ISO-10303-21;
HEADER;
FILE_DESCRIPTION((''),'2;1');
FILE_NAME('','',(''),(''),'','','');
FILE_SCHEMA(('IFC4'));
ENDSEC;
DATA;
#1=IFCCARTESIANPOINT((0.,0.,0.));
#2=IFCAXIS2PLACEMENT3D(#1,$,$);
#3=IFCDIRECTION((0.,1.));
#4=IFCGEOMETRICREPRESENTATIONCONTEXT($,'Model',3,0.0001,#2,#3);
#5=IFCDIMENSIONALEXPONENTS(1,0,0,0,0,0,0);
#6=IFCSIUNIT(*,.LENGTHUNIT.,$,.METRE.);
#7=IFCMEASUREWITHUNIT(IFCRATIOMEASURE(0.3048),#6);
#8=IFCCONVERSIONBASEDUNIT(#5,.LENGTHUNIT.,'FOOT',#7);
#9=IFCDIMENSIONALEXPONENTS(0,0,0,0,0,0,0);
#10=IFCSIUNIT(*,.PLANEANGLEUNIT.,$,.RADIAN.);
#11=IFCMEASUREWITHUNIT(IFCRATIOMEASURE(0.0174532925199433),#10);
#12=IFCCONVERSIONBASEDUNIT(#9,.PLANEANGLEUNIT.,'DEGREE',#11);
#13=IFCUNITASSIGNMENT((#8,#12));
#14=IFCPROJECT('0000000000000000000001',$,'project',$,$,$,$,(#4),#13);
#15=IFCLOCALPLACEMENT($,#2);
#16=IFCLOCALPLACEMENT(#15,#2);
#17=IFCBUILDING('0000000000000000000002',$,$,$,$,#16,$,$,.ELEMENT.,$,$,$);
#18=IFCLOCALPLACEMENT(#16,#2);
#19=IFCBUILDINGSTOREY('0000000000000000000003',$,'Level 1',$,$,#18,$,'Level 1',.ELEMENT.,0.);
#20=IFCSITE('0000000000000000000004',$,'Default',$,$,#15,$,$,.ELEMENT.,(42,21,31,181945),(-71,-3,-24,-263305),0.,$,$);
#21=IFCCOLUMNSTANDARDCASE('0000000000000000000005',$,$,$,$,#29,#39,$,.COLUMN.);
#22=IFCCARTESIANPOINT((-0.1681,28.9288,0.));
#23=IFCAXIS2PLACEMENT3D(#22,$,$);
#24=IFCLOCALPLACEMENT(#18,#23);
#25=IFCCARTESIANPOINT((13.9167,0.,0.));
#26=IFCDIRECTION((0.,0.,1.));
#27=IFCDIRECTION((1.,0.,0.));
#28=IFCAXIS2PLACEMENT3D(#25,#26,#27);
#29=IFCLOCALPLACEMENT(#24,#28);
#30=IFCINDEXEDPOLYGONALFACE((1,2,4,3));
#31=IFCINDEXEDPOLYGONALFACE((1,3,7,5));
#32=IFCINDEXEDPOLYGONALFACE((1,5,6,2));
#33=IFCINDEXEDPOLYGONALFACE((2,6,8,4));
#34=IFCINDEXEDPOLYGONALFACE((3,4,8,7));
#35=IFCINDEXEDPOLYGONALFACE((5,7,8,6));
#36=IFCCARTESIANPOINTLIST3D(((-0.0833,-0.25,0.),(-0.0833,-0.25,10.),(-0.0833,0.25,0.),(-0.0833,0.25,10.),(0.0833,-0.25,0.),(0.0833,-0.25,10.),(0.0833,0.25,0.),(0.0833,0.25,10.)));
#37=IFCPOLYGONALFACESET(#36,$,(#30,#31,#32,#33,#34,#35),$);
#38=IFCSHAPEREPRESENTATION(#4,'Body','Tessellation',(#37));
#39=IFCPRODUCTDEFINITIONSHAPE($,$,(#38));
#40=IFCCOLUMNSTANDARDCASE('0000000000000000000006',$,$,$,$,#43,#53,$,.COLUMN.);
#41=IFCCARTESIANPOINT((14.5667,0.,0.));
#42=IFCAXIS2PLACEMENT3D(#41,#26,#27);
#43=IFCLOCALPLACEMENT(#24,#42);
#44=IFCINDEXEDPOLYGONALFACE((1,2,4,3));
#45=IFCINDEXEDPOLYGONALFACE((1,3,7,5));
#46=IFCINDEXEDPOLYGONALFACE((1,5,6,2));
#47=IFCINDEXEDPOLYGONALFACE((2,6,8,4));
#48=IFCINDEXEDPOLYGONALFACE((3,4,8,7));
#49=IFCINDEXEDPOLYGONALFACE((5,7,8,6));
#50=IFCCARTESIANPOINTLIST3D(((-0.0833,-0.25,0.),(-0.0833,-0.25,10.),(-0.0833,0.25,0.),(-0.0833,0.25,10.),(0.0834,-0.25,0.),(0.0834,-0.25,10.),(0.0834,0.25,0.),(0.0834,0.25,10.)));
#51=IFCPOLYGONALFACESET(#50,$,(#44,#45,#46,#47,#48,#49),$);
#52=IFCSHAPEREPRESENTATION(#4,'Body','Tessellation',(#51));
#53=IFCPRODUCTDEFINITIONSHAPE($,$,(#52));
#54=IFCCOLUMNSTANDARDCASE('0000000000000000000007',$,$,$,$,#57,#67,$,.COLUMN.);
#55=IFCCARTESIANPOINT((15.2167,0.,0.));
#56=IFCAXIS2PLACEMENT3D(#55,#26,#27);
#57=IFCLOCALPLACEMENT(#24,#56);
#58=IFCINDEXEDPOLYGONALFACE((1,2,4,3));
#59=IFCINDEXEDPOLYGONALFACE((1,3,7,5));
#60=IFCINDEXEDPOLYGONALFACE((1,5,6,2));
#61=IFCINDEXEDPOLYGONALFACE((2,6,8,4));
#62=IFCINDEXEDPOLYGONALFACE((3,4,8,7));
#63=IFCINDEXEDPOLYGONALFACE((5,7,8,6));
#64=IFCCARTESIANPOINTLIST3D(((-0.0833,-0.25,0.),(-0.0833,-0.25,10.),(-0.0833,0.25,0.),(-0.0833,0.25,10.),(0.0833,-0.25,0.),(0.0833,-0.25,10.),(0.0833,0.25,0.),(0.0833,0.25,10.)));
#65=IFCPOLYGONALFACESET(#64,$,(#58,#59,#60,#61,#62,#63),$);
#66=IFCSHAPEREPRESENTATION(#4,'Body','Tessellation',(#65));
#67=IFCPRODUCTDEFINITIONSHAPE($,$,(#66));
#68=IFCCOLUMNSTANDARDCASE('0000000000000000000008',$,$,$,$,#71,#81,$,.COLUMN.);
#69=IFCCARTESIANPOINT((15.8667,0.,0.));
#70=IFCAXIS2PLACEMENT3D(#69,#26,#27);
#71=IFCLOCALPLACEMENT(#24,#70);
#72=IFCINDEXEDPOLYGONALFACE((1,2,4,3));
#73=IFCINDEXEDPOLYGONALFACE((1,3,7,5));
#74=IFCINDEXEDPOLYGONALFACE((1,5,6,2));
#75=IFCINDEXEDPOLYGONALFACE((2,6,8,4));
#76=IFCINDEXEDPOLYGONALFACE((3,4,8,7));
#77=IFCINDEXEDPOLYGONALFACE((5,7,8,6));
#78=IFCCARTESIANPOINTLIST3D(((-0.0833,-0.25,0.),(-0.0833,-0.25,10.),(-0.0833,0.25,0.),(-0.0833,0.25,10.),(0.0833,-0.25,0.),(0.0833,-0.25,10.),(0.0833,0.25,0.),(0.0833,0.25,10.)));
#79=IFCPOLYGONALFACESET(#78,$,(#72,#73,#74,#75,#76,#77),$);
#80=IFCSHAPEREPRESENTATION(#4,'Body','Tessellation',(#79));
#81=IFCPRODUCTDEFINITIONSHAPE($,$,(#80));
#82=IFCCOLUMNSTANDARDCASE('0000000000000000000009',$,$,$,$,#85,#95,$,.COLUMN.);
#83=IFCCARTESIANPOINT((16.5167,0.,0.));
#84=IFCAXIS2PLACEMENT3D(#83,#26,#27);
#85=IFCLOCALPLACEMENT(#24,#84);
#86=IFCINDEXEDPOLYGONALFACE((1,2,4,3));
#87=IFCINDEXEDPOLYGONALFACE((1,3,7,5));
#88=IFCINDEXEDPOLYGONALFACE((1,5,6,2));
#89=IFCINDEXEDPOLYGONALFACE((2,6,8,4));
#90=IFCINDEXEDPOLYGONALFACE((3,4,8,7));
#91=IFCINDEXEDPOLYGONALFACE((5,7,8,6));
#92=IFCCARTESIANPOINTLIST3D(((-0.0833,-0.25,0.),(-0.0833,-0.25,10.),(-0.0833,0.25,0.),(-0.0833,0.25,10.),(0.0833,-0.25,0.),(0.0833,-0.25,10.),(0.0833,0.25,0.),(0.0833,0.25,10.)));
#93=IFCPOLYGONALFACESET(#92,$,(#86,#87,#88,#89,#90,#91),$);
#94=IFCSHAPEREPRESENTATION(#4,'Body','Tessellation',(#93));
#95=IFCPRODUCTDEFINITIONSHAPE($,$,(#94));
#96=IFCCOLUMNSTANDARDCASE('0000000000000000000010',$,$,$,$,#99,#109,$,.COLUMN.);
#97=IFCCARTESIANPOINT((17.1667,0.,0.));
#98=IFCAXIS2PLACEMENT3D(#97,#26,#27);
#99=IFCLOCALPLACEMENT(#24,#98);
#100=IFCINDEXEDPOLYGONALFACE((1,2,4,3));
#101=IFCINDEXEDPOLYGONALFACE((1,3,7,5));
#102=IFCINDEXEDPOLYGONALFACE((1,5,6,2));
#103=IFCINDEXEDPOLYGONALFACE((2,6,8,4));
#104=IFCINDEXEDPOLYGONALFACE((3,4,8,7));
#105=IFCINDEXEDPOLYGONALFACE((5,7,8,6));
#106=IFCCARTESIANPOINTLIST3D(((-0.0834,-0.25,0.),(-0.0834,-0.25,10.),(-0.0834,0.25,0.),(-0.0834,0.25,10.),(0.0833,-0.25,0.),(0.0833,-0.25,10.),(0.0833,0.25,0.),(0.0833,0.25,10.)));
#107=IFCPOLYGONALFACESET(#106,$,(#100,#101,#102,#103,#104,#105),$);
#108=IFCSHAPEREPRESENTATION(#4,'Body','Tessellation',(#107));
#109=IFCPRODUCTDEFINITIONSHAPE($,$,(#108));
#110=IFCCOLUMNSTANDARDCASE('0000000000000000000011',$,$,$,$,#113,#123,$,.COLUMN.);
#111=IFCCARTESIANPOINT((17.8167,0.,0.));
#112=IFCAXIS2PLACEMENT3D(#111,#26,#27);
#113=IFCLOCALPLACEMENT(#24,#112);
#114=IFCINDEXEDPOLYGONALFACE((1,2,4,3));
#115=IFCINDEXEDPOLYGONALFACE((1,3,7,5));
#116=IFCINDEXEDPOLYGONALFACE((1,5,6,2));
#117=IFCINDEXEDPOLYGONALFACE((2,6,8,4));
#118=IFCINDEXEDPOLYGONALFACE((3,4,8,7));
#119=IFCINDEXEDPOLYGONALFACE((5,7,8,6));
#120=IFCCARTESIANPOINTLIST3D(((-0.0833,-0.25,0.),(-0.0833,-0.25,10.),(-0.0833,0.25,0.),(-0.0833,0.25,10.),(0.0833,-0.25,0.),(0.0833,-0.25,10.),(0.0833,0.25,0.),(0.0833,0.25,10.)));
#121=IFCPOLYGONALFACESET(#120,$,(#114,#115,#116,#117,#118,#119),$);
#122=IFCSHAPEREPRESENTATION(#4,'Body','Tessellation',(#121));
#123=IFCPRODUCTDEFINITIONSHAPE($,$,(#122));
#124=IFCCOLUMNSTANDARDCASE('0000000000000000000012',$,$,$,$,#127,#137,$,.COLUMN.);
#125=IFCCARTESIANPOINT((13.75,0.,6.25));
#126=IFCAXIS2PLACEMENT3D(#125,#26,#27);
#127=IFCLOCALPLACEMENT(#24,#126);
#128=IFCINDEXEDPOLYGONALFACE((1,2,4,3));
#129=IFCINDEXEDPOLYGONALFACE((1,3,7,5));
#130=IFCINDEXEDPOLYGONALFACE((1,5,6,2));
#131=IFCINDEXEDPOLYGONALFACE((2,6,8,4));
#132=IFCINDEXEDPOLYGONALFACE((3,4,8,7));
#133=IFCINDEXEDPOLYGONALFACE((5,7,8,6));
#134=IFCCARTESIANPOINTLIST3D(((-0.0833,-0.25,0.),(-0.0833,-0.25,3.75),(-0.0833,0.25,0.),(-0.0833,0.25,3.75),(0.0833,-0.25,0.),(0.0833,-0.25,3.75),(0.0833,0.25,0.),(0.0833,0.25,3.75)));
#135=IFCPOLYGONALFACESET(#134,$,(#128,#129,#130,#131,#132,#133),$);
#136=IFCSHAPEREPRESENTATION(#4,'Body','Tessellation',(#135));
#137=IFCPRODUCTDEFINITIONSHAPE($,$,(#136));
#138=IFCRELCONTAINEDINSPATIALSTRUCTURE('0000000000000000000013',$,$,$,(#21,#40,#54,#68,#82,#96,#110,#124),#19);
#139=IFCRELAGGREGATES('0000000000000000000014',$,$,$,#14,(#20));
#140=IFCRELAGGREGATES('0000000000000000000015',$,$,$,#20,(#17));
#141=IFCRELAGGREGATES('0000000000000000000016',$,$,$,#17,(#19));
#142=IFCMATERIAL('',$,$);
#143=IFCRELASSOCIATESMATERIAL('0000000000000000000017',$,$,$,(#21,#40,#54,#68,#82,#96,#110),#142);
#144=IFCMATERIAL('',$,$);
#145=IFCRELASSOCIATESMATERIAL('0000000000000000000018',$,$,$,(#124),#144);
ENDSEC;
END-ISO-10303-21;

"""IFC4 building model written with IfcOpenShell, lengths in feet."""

from ifc_helpers import new_model, entity, si_unit, converted_unit, direction, frame, origin, place, context, project, spatial, rectangle, extrude, material, element, save


model = new_model("IFC4")

# Units and contexts
model_context = context("Model", 3, precision=0.0001, world=origin(), true_north=direction((0.0, 1.0)))
ifc_project = project(units=[converted_unit("LENGTHUNIT", "FOOT", entity("IfcRatioMeasure", 0.3048), si_unit("LENGTHUNIT", "METRE"), dimensions=[1, 0, 0, 0, 0, 0, 0]), converted_unit("PLANEANGLEUNIT", "DEGREE", entity("IfcRatioMeasure", 0.0174532925199433), si_unit("PLANEANGLEUNIT", "RADIAN"), dimensions=[0, 0, 0, 0, 0, 0, 0])], contexts=[model_context])

# Site, building, storey
site_placement = place(None, origin())
site = spatial("IfcSite", under=ifc_project, at=site_placement, Name="Default", CompositionType="ELEMENT", RefLatitude=(42, 21, 31, 181945), RefLongitude=(-71, -3, -24, -263305), RefElevation=0.0)
building_placement = place(site_placement, origin())
building = spatial("IfcBuilding", under=site, at=building_placement, CompositionType="ELEMENT")
storey_placement = place(building_placement, origin())
storey = spatial("IfcBuildingStorey", under=building, at=storey_placement, Name="Level 1", LongName="Level 1", CompositionType="ELEMENT", Elevation=0.0)

# Columns
ifc_material_1 = material(Name="")
placement = place(storey_placement, frame((-0.1681, 28.9288, 0.0)))
for number, where, z_axis, x_axis in (
    (1, (13.9167, 0.0, 0.0), (0.0, 0.0, 1.0), (1.0, 0.0, 0.0)),
    (2, (14.5667, 0.0, 0.0), (0.0, 0.0, 1.0), (1.0, 0.0, 0.0)),
    (3, (15.2167, 0.0, 0.0), (0.0, 0.0, 1.0), (1.0, 0.0, 0.0)),
    (4, (15.8667, 0.0, 0.0), (0.0, 0.0, 1.0), (1.0, 0.0, 0.0)),
    (5, (16.5167, 0.0, 0.0), (0.0, 0.0, 1.0), (1.0, 0.0, 0.0)),
    (6, (17.1667, 0.0, 0.0), (0.0, 0.0, 1.0), (1.0, 0.0, 0.0)),
    (7, (17.8167, 0.0, 0.0), (0.0, 0.0, 1.0), (1.0, 0.0, 0.0)),
):
    element("IfcColumnStandardCase", number, at=place(placement, frame(where, z_axis=z_axis, x_axis=x_axis)), inside=storey, material=ifc_material_1, PredefinedType="COLUMN", context=model_context, shape_type="SweptSolid", body=[
        extrude(rectangle(XDim=0.1667, YDim=0.5), origin(), (0.0, 0.0, 1.0), 10.0),
    ])
ifc_material_2 = material(Name="")
for number, where, z_axis, x_axis in (
    (8, (13.75, 0.0, 6.25), (0.0, 0.0, 1.0), (1.0, 0.0, 0.0)),
):
    element("IfcColumnStandardCase", number, at=place(placement, frame(where, z_axis=z_axis, x_axis=x_axis)), inside=storey, material=ifc_material_2, PredefinedType="COLUMN", context=model_context, shape_type="SweptSolid", body=[
        extrude(rectangle(XDim=0.1667, YDim=0.5), origin(), (0.0, 0.0, 1.0), 3.75),
    ])

save(model, "model.ifc")
